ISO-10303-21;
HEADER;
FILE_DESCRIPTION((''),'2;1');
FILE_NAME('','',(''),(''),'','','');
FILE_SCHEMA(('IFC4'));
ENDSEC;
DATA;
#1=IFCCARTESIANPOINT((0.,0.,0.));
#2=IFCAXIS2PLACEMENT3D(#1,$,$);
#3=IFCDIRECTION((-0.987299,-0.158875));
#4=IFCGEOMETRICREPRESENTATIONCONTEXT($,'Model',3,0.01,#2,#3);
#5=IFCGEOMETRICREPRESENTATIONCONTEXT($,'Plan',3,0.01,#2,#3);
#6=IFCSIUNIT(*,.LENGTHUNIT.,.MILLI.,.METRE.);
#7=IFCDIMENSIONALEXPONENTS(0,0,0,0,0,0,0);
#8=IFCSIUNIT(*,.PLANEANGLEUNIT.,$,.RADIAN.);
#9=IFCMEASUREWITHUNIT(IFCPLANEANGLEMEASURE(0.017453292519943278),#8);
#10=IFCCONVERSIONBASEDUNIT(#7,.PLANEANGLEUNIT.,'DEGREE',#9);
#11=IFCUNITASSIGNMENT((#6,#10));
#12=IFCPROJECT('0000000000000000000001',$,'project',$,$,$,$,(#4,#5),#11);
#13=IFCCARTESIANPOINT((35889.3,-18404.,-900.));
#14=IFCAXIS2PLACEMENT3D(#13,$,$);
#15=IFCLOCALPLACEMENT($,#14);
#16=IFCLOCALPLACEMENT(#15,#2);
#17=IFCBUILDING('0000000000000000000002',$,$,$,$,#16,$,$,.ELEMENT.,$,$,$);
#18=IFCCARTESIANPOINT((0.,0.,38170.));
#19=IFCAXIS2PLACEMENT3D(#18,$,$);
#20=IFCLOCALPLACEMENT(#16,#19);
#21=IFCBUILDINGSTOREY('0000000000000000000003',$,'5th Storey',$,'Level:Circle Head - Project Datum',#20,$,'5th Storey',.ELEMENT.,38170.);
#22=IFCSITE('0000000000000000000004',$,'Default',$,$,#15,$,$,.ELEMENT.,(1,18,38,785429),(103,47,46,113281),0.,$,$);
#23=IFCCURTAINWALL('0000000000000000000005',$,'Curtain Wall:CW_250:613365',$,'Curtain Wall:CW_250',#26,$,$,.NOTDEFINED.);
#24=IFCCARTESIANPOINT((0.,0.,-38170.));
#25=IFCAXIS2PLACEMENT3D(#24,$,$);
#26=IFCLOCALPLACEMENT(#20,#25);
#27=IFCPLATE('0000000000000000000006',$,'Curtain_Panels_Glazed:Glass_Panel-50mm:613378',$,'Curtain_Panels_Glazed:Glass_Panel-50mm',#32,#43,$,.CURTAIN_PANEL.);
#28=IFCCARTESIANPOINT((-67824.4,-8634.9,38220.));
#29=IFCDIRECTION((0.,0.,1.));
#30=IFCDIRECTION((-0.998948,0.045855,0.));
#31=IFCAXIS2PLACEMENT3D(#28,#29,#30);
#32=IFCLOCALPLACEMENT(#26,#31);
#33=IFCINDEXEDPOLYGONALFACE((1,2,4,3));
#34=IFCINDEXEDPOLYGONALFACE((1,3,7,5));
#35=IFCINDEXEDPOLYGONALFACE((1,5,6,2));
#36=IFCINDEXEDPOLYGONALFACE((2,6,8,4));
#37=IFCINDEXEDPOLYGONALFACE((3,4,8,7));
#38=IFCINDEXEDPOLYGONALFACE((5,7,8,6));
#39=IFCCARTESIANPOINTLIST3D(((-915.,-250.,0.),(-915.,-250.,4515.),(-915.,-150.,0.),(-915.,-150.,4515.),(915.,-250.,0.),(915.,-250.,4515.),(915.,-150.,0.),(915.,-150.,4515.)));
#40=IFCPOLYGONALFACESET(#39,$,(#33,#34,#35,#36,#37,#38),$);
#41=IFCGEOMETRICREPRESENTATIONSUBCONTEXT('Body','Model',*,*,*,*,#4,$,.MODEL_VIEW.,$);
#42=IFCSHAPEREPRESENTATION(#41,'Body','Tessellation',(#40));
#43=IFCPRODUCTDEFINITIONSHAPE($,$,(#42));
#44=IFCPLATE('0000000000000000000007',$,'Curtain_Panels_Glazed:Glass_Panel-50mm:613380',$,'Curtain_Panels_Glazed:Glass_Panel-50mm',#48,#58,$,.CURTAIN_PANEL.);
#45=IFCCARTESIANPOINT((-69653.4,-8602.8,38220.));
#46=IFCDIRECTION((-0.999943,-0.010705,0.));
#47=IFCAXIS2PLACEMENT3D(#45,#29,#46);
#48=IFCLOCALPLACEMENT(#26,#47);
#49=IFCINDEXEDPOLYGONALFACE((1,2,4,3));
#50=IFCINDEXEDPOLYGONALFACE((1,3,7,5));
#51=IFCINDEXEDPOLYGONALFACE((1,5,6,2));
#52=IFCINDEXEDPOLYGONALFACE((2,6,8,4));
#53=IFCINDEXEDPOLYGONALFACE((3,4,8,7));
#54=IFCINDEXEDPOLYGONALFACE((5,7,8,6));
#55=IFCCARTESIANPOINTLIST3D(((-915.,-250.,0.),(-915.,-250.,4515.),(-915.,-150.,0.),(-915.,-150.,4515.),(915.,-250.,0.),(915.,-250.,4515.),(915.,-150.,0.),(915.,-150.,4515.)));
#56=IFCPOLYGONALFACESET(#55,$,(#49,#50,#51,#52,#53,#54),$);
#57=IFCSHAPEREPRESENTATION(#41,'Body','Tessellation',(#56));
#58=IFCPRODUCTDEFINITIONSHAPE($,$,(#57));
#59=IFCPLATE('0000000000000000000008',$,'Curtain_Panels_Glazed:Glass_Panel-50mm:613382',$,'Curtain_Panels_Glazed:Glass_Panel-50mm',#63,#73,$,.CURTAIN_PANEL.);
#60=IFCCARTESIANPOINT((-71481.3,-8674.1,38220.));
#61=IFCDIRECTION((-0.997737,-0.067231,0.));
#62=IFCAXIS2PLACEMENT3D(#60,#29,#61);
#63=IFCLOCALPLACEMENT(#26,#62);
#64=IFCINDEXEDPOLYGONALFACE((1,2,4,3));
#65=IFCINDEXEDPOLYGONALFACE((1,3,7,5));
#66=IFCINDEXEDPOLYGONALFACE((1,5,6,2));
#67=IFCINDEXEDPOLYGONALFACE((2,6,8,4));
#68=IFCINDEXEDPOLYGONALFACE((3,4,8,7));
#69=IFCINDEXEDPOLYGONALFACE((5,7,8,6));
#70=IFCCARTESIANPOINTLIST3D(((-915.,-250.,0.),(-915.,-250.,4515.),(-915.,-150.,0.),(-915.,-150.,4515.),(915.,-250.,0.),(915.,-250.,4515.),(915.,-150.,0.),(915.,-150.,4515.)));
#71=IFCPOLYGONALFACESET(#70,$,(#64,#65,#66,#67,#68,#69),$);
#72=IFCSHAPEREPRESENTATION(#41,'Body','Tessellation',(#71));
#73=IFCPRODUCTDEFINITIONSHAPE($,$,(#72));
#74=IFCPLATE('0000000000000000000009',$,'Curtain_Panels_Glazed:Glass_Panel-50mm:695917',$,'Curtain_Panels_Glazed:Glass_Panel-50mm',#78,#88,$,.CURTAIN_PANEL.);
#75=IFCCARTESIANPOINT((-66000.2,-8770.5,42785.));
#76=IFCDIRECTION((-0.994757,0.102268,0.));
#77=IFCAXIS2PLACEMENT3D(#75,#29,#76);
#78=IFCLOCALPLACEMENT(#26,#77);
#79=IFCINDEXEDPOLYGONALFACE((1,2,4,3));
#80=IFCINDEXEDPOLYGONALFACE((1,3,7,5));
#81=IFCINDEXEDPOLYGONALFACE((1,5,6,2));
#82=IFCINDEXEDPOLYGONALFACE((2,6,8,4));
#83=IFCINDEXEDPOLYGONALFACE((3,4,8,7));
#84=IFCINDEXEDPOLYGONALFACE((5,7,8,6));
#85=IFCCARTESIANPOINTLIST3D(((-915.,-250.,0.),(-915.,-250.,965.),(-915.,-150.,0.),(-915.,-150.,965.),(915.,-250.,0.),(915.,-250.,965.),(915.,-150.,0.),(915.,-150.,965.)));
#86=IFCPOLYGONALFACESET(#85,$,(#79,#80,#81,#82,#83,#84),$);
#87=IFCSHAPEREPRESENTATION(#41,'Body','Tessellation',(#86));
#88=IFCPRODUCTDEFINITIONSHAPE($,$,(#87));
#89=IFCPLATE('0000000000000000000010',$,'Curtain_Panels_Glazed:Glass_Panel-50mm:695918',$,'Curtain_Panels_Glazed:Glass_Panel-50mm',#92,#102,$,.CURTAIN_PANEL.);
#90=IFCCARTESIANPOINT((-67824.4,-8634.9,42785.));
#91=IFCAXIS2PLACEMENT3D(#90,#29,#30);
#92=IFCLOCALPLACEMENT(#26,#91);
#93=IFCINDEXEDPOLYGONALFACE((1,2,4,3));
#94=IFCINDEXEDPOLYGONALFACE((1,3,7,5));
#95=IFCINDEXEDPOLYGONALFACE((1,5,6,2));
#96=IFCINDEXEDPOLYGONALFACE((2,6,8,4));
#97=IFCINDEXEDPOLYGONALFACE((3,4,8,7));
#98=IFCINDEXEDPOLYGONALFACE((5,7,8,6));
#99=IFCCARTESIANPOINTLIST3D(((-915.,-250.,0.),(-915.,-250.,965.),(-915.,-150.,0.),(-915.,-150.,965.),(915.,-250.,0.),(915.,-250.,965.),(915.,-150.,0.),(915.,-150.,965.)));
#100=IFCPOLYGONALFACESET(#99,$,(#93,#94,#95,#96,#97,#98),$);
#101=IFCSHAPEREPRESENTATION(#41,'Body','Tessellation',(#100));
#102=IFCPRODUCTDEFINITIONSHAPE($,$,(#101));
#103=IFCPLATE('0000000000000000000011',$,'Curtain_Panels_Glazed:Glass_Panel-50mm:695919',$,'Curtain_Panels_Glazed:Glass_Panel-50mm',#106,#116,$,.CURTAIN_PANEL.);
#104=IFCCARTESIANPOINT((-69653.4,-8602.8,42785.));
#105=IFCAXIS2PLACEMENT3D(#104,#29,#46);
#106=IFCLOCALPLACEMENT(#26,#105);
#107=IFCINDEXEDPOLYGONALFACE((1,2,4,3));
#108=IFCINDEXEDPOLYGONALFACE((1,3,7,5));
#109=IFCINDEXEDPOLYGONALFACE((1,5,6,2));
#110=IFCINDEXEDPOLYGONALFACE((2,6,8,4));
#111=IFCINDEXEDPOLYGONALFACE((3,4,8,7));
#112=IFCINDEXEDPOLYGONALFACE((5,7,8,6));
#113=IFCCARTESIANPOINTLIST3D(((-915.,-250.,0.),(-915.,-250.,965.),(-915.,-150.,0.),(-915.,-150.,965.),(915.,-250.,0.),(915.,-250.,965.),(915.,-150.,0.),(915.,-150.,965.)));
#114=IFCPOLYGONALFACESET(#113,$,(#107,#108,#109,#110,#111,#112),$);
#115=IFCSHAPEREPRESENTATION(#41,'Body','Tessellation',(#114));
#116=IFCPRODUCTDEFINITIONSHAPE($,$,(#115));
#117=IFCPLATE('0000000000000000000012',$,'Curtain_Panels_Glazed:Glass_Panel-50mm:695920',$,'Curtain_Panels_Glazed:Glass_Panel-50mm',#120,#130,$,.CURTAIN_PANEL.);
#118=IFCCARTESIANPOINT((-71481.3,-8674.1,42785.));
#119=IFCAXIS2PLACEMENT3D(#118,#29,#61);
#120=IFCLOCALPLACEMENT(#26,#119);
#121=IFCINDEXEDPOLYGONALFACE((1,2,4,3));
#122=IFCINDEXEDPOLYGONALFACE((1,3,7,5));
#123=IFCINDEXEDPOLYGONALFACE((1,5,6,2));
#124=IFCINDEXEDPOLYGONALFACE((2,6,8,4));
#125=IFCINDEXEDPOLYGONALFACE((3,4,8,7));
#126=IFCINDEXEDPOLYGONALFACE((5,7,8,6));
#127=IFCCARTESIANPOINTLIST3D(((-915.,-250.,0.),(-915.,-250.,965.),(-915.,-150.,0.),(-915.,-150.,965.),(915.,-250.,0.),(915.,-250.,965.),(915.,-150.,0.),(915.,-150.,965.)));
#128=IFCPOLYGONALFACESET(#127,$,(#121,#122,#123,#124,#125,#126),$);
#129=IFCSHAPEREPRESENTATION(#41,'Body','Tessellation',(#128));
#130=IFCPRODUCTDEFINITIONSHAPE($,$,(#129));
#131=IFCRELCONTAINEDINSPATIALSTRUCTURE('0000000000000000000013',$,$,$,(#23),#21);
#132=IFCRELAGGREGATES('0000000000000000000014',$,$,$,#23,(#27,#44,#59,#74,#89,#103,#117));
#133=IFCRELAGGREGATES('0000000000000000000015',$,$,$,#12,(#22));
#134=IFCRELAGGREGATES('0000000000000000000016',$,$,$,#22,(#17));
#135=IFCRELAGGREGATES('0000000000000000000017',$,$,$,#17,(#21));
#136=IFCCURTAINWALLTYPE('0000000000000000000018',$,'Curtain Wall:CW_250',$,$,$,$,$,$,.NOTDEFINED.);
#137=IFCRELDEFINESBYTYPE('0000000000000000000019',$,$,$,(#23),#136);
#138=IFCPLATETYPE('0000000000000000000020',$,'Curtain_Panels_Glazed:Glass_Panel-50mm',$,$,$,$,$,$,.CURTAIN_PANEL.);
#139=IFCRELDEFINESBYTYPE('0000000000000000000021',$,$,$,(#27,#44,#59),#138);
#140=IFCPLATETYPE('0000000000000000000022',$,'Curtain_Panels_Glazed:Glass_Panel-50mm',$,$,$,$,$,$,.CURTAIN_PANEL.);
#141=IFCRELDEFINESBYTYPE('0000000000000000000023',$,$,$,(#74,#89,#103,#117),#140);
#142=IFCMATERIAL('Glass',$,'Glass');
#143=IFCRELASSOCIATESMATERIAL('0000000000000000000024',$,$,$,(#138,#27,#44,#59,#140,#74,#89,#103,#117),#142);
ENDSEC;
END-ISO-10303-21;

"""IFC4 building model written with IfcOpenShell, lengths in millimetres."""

from ifc_helpers import new_model, entity, si_unit, converted_unit, direction, frame, origin, place, context, subcontext, project, spatial, indexed_curve, outline, extrude, source, transform, mapped, material, type_object, type_shapes, element, aggregate, save


model = new_model("IFC4")

# Units and contexts
model_context = context("Model", 3, precision=0.01, world=origin(), true_north=direction((-0.987299, -0.158875)))
plan_context = context("Plan", 3, precision=0.01, world=origin(), true_north=direction((-0.987299, -0.158875)))
body_context = subcontext(model_context, "Body", "Model", "MODEL_VIEW")
ifc_project = project(units=[si_unit("LENGTHUNIT", "METRE", prefix="MILLI"), converted_unit("PLANEANGLEUNIT", "DEGREE", entity("IfcPlaneAngleMeasure", 0.017453292519943278), si_unit("PLANEANGLEUNIT", "RADIAN"), dimensions=[0, 0, 0, 0, 0, 0, 0])], contexts=[model_context, plan_context])

# Site, building, storey
site_placement = place(None, frame((35889.3, -18404.0, -900.0)))
site = spatial("IfcSite", under=ifc_project, at=site_placement, Name="Default", CompositionType="ELEMENT", RefLatitude=(1, 18, 38, 785429), RefLongitude=(103, 47, 46, 113281), RefElevation=0.0)
building_placement = place(site_placement, origin())
building = spatial("IfcBuilding", under=site, at=building_placement, CompositionType="ELEMENT")
storey_placement = place(building_placement, frame((0.0, 0.0, 38170.0)))
storey = spatial("IfcBuildingStorey", under=building, at=storey_placement, Name="5th Storey", ObjectType="Level:Circle Head - Project Datum", LongName="5th Storey", CompositionType="ELEMENT", Elevation=38170.0)

# Curtain wall, plates
curtain_wall_type = type_object("IfcCurtainWallType", Name="Curtain Wall:CW_250", PredefinedType="NOTDEFINED")
curtain_wall_placement = place(storey_placement, frame((0.0, 0.0, -38170.0)))
curtain_wall = element("IfcCurtainWall", 1, at=curtain_wall_placement, inside=storey, type_object=curtain_wall_type, Name="Curtain Wall:CW_250:613365", ObjectType="Curtain Wall:CW_250", PredefinedType="NOTDEFINED")
ifc_material_1 = material(Name="Glass", Category="Glass")
plate_type_1 = type_object("IfcPlateType", Name="Curtain_Panels_Glazed:Glass_Panel-50mm", PredefinedType="CURTAIN_PANEL", material=ifc_material_1)
shared_shape_1 = source(origin(), body_context, "Body", "SweptSolid", [
    extrude(outline(indexed_curve([(-915.0, -50.0), (915.0, -50.0), (915.0, 50.0), (-915.0, 50.0), (-915.0, -50.0)], self_intersect=False)), frame((0.0, -200.0, 0.0), z_axis=(0.0, 0.0, 1.0), x_axis=(-1.0, 0.0, 0.0)), (0.0, 0.0, 1.0), 4515.0),
])
type_shapes(plate_type_1, [shared_shape_1])
plate_1_placement = place(curtain_wall_placement, frame((-67824.4, -8634.9, 38220.0), z_axis=(0.0, 0.0, 1.0), x_axis=(-0.998948, 0.045855, 0.0)))
plate_1 = element("IfcPlate", 2, at=plate_1_placement, type_object=plate_type_1, material=ifc_material_1, Name="Curtain_Panels_Glazed:Glass_Panel-50mm:613378", ObjectType="Curtain_Panels_Glazed:Glass_Panel-50mm", PredefinedType="CURTAIN_PANEL", context=body_context, shape_type="MappedRepresentation", body=[
    mapped(shared_shape_1, transform((0.0, 0.0, 0.0), scale=1.0)),
])
plate_2_placement = place(curtain_wall_placement, frame((-69653.4, -8602.8, 38220.0), z_axis=(0.0, 0.0, 1.0), x_axis=(-0.999943, -0.010705, 0.0)))
plate_2 = element("IfcPlate", 3, at=plate_2_placement, type_object=plate_type_1, material=ifc_material_1, Name="Curtain_Panels_Glazed:Glass_Panel-50mm:613380", ObjectType="Curtain_Panels_Glazed:Glass_Panel-50mm", PredefinedType="CURTAIN_PANEL", context=body_context, shape_type="MappedRepresentation", body=[
    mapped(shared_shape_1, transform((0.0, 0.0, 0.0), scale=1.0)),
])
plate_3_placement = place(curtain_wall_placement, frame((-71481.3, -8674.1, 38220.0), z_axis=(0.0, 0.0, 1.0), x_axis=(-0.997737, -0.067231, 0.0)))
plate_3 = element("IfcPlate", 4, at=plate_3_placement, type_object=plate_type_1, material=ifc_material_1, Name="Curtain_Panels_Glazed:Glass_Panel-50mm:613382", ObjectType="Curtain_Panels_Glazed:Glass_Panel-50mm", PredefinedType="CURTAIN_PANEL", context=body_context, shape_type="MappedRepresentation", body=[
    mapped(shared_shape_1, transform((0.0, 0.0, 0.0), scale=1.0)),
])
plate_type_2 = type_object("IfcPlateType", Name="Curtain_Panels_Glazed:Glass_Panel-50mm", PredefinedType="CURTAIN_PANEL", material=ifc_material_1)
shared_shape_2 = source(origin(), body_context, "Body", "SweptSolid", [
    extrude(outline(indexed_curve([(-915.0, -50.0), (915.0, -50.0), (915.0, 50.0), (-915.0, 50.0), (-915.0, -50.0)], self_intersect=False)), frame((0.0, -200.0, 0.0), z_axis=(0.0, 0.0, 1.0), x_axis=(-1.0, 0.0, 0.0)), (0.0, 0.0, 1.0), 965.0),
])
type_shapes(plate_type_2, [shared_shape_2])
plate_4_placement = place(curtain_wall_placement, frame((-66000.2, -8770.5, 42785.0), z_axis=(0.0, 0.0, 1.0), x_axis=(-0.994757, 0.102268, 0.0)))
plate_4 = element("IfcPlate", 5, at=plate_4_placement, type_object=plate_type_2, material=ifc_material_1, Name="Curtain_Panels_Glazed:Glass_Panel-50mm:695917", ObjectType="Curtain_Panels_Glazed:Glass_Panel-50mm", PredefinedType="CURTAIN_PANEL", context=body_context, shape_type="MappedRepresentation", body=[
    mapped(shared_shape_2, transform((0.0, 0.0, 0.0), scale=1.0)),
])
plate_5_placement = place(curtain_wall_placement, frame((-67824.4, -8634.9, 42785.0), z_axis=(0.0, 0.0, 1.0), x_axis=(-0.998948, 0.045855, 0.0)))
plate_5 = element("IfcPlate", 6, at=plate_5_placement, type_object=plate_type_2, material=ifc_material_1, Name="Curtain_Panels_Glazed:Glass_Panel-50mm:695918", ObjectType="Curtain_Panels_Glazed:Glass_Panel-50mm", PredefinedType="CURTAIN_PANEL", context=body_context, shape_type="MappedRepresentation", body=[
    mapped(shared_shape_2, transform((0.0, 0.0, 0.0), scale=1.0)),
])
plate_6_placement = place(curtain_wall_placement, frame((-69653.4, -8602.8, 42785.0), z_axis=(0.0, 0.0, 1.0), x_axis=(-0.999943, -0.010705, 0.0)))
plate_6 = element("IfcPlate", 7, at=plate_6_placement, type_object=plate_type_2, material=ifc_material_1, Name="Curtain_Panels_Glazed:Glass_Panel-50mm:695919", ObjectType="Curtain_Panels_Glazed:Glass_Panel-50mm", PredefinedType="CURTAIN_PANEL", context=body_context, shape_type="MappedRepresentation", body=[
    mapped(shared_shape_2, transform((0.0, 0.0, 0.0), scale=1.0)),
])
plate_7_placement = place(curtain_wall_placement, frame((-71481.3, -8674.1, 42785.0), z_axis=(0.0, 0.0, 1.0), x_axis=(-0.997737, -0.067231, 0.0)))
plate_7 = element("IfcPlate", 8, at=plate_7_placement, type_object=plate_type_2, material=ifc_material_1, Name="Curtain_Panels_Glazed:Glass_Panel-50mm:695920", ObjectType="Curtain_Panels_Glazed:Glass_Panel-50mm", PredefinedType="CURTAIN_PANEL", context=body_context, shape_type="MappedRepresentation", body=[
    mapped(shared_shape_2, transform((0.0, 0.0, 0.0), scale=1.0)),
])
aggregate(curtain_wall, [plate_1, plate_2, plate_3, plate_4, plate_5, plate_6, plate_7])

save(model, "model.ifc")
